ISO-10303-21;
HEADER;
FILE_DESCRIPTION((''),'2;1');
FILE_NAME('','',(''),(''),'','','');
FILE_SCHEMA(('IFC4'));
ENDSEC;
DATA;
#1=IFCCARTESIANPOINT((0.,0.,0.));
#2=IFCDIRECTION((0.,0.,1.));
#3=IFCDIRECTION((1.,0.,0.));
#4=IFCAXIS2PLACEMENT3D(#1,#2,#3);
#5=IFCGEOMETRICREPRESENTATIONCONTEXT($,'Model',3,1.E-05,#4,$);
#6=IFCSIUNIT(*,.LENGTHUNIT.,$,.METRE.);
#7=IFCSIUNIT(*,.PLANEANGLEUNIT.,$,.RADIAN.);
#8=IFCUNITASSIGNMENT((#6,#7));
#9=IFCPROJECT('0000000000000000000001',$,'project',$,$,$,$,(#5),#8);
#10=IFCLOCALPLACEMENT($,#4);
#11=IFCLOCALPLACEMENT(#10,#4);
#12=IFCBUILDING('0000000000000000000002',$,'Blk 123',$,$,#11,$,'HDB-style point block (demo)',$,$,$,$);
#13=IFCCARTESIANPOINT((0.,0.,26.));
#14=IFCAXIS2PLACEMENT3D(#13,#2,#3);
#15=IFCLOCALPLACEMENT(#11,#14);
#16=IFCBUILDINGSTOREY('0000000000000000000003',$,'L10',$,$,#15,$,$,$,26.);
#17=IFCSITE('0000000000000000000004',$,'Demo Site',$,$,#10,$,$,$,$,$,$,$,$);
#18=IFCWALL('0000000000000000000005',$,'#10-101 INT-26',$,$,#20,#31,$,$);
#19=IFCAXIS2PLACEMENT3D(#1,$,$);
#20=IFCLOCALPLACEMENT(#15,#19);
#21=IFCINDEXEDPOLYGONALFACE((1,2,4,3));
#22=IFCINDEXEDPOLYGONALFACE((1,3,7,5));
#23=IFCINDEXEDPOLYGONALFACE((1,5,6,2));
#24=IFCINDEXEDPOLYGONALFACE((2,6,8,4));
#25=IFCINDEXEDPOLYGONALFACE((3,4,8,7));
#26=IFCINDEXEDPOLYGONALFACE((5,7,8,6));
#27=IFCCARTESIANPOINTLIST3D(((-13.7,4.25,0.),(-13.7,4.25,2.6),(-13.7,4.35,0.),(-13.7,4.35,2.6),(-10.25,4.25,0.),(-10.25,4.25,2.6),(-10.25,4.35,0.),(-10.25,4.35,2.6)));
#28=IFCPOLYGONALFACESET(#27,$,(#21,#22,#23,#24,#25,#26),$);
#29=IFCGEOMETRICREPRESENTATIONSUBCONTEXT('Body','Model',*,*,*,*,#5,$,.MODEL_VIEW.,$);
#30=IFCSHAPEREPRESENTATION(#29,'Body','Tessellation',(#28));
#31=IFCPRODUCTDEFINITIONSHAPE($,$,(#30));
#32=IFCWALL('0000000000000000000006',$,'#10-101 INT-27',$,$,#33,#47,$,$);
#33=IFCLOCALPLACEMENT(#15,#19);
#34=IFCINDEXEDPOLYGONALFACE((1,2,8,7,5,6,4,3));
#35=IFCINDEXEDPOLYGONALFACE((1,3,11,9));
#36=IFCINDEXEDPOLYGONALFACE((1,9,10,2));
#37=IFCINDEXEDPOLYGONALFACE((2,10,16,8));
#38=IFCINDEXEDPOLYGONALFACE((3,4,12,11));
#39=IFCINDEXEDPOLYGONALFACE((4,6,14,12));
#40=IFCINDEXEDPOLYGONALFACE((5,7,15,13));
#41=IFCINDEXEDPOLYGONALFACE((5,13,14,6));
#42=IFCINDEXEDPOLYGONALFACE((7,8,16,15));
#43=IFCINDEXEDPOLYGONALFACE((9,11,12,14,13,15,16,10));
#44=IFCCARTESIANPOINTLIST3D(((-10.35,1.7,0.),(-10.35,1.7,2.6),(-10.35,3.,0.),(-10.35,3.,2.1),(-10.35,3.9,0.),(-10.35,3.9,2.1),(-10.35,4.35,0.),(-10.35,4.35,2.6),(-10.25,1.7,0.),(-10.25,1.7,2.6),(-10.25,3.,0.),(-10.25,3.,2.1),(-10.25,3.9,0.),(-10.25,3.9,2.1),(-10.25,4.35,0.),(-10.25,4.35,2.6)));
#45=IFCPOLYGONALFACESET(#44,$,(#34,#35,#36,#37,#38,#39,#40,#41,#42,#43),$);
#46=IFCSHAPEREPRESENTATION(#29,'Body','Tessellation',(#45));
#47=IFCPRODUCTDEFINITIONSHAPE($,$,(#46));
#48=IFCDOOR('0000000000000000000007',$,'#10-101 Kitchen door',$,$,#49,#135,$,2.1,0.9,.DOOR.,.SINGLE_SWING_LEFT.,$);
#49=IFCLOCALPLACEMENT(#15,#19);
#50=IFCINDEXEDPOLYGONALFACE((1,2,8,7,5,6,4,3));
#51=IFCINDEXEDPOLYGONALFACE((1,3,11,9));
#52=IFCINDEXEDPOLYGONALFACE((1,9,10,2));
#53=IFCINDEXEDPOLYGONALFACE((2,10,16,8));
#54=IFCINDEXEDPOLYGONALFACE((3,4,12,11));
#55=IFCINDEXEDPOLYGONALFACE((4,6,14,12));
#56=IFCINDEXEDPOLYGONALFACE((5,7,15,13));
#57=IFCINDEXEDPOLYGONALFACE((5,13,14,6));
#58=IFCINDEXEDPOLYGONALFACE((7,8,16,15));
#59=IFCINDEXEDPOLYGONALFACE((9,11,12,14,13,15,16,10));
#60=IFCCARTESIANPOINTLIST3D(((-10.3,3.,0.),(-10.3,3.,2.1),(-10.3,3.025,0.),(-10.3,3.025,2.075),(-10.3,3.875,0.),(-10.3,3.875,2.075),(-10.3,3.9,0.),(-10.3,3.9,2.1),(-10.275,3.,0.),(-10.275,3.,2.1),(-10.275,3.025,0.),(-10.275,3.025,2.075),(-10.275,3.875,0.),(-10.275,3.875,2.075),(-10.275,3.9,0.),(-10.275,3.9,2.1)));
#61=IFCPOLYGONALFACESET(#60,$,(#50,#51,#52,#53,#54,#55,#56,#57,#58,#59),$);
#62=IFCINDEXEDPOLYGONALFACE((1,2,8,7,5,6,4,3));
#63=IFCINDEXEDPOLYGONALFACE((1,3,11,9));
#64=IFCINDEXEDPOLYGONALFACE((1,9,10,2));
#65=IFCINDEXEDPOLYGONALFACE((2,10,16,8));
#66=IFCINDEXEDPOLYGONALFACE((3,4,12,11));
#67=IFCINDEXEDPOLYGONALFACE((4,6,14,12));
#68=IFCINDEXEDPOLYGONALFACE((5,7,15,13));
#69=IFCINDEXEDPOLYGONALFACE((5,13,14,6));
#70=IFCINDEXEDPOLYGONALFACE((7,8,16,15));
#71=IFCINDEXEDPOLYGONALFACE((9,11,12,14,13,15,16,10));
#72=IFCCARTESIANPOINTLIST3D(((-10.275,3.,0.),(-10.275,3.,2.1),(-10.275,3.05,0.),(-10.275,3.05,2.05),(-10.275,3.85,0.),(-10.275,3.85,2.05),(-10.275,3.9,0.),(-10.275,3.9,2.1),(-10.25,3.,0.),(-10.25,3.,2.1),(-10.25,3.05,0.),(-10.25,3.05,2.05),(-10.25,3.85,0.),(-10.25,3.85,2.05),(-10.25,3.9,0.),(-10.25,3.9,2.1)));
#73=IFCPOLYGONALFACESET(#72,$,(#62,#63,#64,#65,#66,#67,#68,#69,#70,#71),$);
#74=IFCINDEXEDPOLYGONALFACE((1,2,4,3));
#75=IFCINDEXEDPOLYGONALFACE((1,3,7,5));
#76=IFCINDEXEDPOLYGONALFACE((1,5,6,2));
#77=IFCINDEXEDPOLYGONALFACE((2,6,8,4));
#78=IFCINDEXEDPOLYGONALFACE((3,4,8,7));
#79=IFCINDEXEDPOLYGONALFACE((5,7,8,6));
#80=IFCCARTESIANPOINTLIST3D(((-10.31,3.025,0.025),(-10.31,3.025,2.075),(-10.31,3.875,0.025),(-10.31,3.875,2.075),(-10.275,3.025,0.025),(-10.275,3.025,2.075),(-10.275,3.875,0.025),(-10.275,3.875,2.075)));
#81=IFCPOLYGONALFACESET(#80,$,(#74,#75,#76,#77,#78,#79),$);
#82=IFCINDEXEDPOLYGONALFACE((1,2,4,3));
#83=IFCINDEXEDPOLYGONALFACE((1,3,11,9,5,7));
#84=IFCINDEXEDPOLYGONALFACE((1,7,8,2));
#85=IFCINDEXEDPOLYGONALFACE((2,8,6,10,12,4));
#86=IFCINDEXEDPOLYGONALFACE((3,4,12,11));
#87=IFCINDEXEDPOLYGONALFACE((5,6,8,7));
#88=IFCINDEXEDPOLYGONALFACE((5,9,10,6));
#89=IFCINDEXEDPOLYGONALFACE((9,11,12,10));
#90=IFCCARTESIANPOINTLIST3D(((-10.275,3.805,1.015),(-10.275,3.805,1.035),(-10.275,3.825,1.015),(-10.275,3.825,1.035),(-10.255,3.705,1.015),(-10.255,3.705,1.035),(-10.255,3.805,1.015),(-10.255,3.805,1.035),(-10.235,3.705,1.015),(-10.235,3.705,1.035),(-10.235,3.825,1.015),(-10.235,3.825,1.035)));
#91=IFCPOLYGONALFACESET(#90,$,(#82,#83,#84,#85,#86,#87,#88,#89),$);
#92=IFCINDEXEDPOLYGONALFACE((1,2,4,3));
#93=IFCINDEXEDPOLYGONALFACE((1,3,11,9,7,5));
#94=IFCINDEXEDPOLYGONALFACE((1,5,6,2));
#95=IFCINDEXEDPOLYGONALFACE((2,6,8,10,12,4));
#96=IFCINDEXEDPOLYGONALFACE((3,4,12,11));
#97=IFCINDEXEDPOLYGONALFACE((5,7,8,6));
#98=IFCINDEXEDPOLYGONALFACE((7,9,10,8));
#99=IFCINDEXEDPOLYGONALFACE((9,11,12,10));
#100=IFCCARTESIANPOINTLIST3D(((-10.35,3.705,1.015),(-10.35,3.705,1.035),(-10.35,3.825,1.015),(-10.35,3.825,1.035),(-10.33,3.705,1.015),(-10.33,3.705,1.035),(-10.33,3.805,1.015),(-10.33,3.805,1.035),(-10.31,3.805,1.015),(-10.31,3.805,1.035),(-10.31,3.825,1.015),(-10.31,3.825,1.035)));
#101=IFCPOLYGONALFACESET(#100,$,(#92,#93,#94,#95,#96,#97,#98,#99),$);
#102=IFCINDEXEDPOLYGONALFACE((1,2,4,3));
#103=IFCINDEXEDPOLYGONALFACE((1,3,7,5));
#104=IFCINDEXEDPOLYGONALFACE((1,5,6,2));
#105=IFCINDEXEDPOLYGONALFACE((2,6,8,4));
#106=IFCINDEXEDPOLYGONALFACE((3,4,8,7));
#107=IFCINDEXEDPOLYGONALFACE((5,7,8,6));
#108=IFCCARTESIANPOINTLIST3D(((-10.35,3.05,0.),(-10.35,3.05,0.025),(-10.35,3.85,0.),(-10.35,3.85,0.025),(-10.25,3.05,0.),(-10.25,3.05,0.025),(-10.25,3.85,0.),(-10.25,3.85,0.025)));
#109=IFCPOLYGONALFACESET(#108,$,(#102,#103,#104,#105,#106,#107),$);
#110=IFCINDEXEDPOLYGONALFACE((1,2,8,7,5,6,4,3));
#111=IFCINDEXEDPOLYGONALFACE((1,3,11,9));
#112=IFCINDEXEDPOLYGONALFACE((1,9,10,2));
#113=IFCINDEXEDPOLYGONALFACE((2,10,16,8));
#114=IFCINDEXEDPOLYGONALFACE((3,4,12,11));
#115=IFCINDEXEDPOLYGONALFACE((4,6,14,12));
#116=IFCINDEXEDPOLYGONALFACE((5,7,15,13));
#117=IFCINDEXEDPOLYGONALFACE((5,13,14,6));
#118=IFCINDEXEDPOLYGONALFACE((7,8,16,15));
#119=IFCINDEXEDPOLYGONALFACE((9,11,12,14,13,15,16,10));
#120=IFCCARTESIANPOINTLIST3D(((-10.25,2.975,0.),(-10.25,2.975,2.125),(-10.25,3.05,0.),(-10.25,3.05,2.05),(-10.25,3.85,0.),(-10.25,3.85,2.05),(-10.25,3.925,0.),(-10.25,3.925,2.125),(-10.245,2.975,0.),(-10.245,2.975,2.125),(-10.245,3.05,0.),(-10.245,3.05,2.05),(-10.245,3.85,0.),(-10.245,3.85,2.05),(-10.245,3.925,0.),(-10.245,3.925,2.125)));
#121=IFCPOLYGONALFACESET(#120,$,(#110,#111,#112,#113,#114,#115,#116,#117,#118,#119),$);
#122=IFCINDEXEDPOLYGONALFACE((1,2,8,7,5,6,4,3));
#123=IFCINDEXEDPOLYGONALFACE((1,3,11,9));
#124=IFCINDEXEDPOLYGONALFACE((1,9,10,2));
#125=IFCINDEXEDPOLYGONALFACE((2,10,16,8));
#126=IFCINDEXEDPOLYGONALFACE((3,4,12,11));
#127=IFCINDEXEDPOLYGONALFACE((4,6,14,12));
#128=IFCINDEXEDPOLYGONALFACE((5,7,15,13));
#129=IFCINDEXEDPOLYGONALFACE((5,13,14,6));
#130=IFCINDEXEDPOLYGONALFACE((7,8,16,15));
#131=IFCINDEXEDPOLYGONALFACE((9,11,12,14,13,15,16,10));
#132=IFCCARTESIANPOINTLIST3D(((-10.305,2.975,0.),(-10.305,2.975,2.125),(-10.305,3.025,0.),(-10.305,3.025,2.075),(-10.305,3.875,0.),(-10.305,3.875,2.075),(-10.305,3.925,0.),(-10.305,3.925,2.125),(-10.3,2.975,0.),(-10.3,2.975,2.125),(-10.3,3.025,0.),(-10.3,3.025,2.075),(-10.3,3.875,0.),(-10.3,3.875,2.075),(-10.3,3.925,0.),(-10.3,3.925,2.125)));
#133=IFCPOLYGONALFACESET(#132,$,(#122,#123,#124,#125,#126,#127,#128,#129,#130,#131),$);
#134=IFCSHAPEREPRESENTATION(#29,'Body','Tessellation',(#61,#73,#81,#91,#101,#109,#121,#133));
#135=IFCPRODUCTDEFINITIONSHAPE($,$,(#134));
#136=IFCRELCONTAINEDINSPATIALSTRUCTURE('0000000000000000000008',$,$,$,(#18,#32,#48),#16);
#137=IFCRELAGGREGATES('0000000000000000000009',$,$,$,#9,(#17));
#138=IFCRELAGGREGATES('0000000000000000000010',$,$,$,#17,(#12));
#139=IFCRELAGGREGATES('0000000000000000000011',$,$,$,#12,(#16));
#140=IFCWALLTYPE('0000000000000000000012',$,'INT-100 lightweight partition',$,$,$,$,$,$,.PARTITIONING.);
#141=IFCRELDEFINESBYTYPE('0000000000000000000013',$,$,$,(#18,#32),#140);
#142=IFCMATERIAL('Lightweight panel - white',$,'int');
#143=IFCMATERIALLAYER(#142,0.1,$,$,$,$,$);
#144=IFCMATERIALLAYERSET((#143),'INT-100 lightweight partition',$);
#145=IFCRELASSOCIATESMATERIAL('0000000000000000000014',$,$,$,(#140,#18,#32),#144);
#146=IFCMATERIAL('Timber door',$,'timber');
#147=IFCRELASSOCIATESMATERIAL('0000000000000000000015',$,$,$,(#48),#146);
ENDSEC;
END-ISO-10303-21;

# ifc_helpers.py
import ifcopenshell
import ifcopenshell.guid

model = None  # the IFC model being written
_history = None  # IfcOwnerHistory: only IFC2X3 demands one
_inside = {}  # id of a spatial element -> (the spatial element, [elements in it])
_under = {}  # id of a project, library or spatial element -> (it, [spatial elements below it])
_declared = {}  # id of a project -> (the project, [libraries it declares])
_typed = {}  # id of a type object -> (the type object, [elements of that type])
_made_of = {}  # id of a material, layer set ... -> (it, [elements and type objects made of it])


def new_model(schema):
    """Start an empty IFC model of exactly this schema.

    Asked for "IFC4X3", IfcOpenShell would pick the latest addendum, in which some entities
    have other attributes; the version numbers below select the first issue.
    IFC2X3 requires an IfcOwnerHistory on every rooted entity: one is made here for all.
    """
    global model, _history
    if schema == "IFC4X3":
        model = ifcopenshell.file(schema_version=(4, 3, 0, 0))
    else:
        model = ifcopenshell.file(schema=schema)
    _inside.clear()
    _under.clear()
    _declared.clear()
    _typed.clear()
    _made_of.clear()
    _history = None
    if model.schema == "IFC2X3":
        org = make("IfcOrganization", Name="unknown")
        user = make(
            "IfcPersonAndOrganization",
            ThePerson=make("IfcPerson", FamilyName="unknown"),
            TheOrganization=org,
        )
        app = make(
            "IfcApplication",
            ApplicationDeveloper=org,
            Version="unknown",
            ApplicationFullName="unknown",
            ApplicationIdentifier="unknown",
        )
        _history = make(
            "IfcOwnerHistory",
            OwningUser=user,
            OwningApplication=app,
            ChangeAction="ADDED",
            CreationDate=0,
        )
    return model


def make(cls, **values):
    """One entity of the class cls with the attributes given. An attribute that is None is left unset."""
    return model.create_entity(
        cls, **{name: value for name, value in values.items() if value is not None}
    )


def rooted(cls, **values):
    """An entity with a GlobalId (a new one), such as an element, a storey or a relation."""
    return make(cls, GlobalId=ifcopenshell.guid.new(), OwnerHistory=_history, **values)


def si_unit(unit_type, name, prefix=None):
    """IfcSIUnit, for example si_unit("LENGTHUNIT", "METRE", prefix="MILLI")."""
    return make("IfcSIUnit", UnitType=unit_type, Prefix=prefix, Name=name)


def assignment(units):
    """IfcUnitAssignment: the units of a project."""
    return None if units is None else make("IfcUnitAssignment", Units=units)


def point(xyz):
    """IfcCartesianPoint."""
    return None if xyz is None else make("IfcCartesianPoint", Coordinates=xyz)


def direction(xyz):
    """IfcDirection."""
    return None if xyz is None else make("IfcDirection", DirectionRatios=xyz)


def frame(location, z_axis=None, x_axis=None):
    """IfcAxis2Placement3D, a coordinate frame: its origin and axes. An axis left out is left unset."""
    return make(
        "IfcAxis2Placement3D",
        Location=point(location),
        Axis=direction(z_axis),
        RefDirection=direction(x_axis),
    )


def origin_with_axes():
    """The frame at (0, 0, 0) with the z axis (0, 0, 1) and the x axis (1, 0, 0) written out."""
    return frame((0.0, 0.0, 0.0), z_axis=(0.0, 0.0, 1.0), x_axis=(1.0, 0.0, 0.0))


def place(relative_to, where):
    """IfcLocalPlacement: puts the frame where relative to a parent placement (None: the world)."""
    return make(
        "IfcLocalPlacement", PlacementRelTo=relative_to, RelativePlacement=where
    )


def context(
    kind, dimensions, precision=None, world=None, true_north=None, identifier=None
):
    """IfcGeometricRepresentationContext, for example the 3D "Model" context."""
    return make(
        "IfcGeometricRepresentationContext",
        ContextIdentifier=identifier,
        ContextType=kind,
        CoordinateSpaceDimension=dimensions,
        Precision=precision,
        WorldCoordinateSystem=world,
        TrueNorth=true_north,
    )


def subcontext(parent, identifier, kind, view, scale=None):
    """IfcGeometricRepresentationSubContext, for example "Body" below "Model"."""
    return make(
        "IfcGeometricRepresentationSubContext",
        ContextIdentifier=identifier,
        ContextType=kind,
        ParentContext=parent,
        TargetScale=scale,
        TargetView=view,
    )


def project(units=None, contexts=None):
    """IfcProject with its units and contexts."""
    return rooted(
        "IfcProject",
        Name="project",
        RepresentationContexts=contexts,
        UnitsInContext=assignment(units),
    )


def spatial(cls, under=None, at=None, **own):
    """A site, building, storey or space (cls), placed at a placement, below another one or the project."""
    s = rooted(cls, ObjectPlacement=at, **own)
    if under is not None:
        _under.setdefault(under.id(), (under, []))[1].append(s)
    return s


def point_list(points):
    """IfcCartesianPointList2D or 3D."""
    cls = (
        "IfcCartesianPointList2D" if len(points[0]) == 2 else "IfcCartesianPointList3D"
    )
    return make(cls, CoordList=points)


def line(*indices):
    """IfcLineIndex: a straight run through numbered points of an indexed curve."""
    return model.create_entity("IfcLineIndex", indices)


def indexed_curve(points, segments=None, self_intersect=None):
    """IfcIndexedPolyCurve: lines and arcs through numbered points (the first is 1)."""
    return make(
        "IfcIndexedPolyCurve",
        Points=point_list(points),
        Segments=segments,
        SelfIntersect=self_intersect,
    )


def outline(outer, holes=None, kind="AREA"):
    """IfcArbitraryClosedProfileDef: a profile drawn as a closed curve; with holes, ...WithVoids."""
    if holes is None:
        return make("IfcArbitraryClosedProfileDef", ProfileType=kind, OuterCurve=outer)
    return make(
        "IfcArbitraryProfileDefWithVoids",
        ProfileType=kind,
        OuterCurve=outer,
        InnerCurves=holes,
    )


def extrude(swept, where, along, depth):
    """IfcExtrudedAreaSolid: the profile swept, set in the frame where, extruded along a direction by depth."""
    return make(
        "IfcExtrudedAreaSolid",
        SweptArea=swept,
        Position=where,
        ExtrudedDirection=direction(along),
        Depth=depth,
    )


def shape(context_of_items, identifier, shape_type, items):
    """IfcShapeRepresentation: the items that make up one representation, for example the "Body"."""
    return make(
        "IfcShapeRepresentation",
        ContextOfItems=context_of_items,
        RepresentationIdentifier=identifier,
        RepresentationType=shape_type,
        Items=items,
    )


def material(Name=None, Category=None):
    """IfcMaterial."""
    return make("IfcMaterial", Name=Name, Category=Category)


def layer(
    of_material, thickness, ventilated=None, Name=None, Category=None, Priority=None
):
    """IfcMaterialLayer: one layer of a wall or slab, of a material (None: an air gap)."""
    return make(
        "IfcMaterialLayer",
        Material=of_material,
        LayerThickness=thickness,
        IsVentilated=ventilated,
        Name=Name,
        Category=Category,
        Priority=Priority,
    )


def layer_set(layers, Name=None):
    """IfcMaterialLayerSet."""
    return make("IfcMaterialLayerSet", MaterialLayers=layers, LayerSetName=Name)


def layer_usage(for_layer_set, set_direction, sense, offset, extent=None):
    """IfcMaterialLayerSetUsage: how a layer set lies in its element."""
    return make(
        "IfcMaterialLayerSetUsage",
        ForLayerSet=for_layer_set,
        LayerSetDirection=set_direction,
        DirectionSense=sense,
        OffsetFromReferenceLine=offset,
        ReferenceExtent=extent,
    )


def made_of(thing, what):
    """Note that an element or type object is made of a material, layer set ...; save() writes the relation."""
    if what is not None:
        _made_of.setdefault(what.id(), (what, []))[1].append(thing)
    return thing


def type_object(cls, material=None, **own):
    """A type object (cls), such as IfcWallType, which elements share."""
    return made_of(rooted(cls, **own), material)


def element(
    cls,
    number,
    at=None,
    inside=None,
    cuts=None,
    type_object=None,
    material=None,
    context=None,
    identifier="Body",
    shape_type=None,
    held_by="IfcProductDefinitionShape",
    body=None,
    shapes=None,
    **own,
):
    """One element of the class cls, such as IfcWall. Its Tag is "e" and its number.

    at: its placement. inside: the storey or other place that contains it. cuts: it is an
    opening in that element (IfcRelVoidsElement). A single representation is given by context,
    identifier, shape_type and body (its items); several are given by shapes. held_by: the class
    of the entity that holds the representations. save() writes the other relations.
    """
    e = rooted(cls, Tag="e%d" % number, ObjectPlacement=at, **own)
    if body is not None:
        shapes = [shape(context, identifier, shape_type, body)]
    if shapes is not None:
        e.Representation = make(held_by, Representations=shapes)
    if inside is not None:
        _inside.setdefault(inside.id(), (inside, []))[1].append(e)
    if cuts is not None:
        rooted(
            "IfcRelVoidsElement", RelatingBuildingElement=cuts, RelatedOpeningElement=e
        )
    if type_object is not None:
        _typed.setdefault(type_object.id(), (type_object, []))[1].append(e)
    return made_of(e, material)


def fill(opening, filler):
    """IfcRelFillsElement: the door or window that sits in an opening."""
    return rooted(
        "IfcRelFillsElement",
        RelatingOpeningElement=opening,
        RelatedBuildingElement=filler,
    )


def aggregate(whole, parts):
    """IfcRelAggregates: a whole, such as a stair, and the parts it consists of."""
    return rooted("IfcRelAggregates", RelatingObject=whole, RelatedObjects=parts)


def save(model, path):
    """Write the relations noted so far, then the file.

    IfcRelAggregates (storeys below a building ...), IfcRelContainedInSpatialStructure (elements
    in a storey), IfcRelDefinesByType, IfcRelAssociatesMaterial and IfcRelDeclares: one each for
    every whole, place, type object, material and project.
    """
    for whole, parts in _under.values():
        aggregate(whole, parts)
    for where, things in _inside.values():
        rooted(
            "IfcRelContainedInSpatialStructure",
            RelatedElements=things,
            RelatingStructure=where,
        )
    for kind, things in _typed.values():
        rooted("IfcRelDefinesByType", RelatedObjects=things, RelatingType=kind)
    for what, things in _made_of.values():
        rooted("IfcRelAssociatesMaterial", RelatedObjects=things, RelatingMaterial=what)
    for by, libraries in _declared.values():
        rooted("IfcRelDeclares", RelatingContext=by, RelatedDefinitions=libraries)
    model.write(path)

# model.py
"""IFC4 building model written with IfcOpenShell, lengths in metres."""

from ifc_helpers import new_model, si_unit, frame, origin_with_axes, place, context, subcontext, project, spatial, line, indexed_curve, outline, extrude, material, layer, layer_set, layer_usage, type_object, element, fill, save


model = new_model("IFC4")

# Units and contexts
model_context = context("Model", 3, precision=1e-05, world=origin_with_axes())
body_context = subcontext(model_context, "Body", "Model", "MODEL_VIEW")
ifc_project = project(units=[si_unit("LENGTHUNIT", "METRE"), si_unit("PLANEANGLEUNIT", "RADIAN")], contexts=[model_context])

# Site, building, storey
site_placement = place(None, origin_with_axes())
site = spatial("IfcSite", under=ifc_project, at=site_placement, Name="Demo Site")
building_placement = place(site_placement, origin_with_axes())
building = spatial("IfcBuilding", under=site, at=building_placement, Name="Blk 123", LongName="HDB-style point block (demo)")
storey_placement = place(building_placement, frame((0.0, 0.0, 26.0), z_axis=(0.0, 0.0, 1.0), x_axis=(1.0, 0.0, 0.0)))
storey = spatial("IfcBuildingStorey", under=building, at=storey_placement, Name="L10", Elevation=26.0)

# Shared definitions
ifc_material_1 = material(Name="Timber door", Category="timber")

# Wall
ifc_material_2 = material(Name="Lightweight panel - white", Category="int")
ifc_layer_1 = layer(ifc_material_2, 0.1)
ifc_layer_set_1 = layer_set([ifc_layer_1], Name="INT-100 lightweight partition")
ifc_layer_usage_1 = layer_usage(ifc_layer_set_1, "AXIS2", "POSITIVE", -0.05)
wall_type_1 = type_object("IfcWallType", Name="INT-100 lightweight partition", PredefinedType="PARTITIONING", material=ifc_layer_set_1)
wall_1_placement = place(storey_placement, frame((-10.25, 4.3, 0.0), z_axis=(0.0, 0.0, 1.0), x_axis=(-1.0, 0.0, 0.0)))
element("IfcWall", 1, at=wall_1_placement, inside=storey, type_object=wall_type_1, material=ifc_layer_usage_1, Name="#10-101 INT-26", context=body_context, shape_type="SweptSolid", body=[
    extrude(outline(indexed_curve([(0.0, 0.0), (0.0, 0.1), (3.45, 0.1), (3.45, 0.0), (0.0, 0.0)], self_intersect=False)), frame((0.0, -0.05, 0.0), z_axis=(0.0, 0.0, 1.0), x_axis=(1.0, 0.0, 0.0)), (0.0, 0.0, 1.0), 2.6),
])

# Wall, opening, door
wall_2_placement = place(storey_placement, frame((-10.3, 1.7, 0.0), z_axis=(0.0, 0.0, 1.0), x_axis=(0.0, 1.0, 0.0)))
wall_2 = element("IfcWall", 2, at=wall_2_placement, inside=storey, type_object=wall_type_1, material=ifc_layer_usage_1, Name="#10-101 INT-27", context=body_context, shape_type="SweptSolid", body=[
    extrude(outline(indexed_curve([(0.0, 0.0), (0.0, 0.1), (2.65, 0.1), (2.65, 0.0), (0.0, 0.0)], self_intersect=False)), frame((0.0, -0.05, 0.0), z_axis=(0.0, 0.0, 1.0), x_axis=(1.0, 0.0, 0.0)), (0.0, 0.0, 1.0), 2.6),
])
opening_1_placement = place(wall_2_placement, frame((1.3, -0.15, 0.0), z_axis=(0.0, 0.0, 1.0), x_axis=(1.0, 0.0, 0.0)))
opening_1 = element("IfcOpeningElement", 3, at=opening_1_placement, cuts=wall_2, context=body_context, shape_type="SweptSolid", body=[
    extrude(outline(indexed_curve([(0.0, 0.0), (0.0, 0.3), (0.9, 0.3), (0.9, 0.0), (0.0, 0.0)], self_intersect=False)), origin_with_axes(), (0.0, 0.0, 1.0), 2.1),
])
door_1_placement = place(opening_1_placement, frame((0.0, 0.1, 0.0), z_axis=(0.0, 0.0, 1.0), x_axis=(1.0, 0.0, 0.0)))
door_1 = element("IfcDoor", 4, at=door_1_placement, inside=storey, material=ifc_material_1, Name="#10-101 Kitchen door", OperationType="SINGLE_SWING_LEFT", OverallHeight=2.1, OverallWidth=0.9, PredefinedType="DOOR", context=body_context, shape_type="SweptSolid", body=[
    extrude(outline(indexed_curve([(0.0, 0.0), (0.0, 2.1), (0.9, 2.1), (0.9, 0.0), (0.875, 0.0), (0.875, 2.075), (0.025, 2.075), (0.025, 0.0)], segments=[line(1, 2, 3, 4, 5, 6, 7, 8, 1)])), frame((0.0, 0.025, 0.0), z_axis=(0.0, -1.0, 0.0), x_axis=(1.0, 0.0, 0.0)), (0.0, 0.0, -1.0), 0.025),
    extrude(outline(indexed_curve([(0.0, 0.0), (0.0, 2.1), (0.9, 2.1), (0.9, 0.0), (0.85, 0.0), (0.85, 2.05), (0.05, 2.05), (0.05, 0.0)], segments=[line(1, 2, 3, 4, 5, 6, 7, 8, 1)])), frame((0.0, 0.0, 0.0), z_axis=(0.0, -1.0, 0.0), x_axis=(1.0, 0.0, 0.0)), (0.0, 0.0, -1.0), 0.025),
    extrude(outline(indexed_curve([(0.0, 0.0), (0.85, 0.0), (0.85, 0.035), (0.0, 0.035)], segments=[line(1, 2, 3, 4, 1)])), frame((0.025, 0.025, 0.025), z_axis=(0.0, 0.0, 1.0), x_axis=(1.0, 0.0, 0.0)), (0.0, 0.0, 1.0), 2.05),
    extrude(outline(indexed_curve([(0.0, 0.0), (0.0, -0.04), (-0.12, -0.04), (-0.12, -0.02), (-0.02, -0.02), (-0.02, 0.0)], segments=[line(1, 2, 3, 4, 5, 6, 1)])), frame((0.825, 0.025, 1.015), z_axis=(0.0, 0.0, 1.0), x_axis=(1.0, 0.0, 0.0)), (0.0, 0.0, 1.0), 0.02),
    extrude(outline(indexed_curve([(0.0, 0.0), (0.0, 0.04), (-0.12, 0.04), (-0.12, 0.02), (-0.02, 0.02), (-0.02, 0.0)], segments=[line(1, 2, 3, 4, 5, 6, 1)])), frame((0.825, 0.06, 1.015), z_axis=(0.0, 0.0, 1.0), x_axis=(1.0, 0.0, 0.0)), (0.0, 0.0, 1.0), 0.02),
    extrude(outline(indexed_curve([(0.0, 0.0), (0.8, 0.0), (0.8, 0.1), (0.0, 0.1)], segments=[line(1, 2, 3, 4, 1)])), frame((0.05, 0.0, 0.0), z_axis=(0.0, 0.0, 1.0), x_axis=(1.0, 0.0, 0.0)), (0.0, 0.0, 1.0), 0.025),
    extrude(outline(indexed_curve([(0.0, 0.0), (0.0, 2.125), (0.95, 2.125), (0.95, 0.0), (0.875, 0.0), (0.875, 2.05), (0.075, 2.05), (0.075, 0.0)], segments=[line(1, 2, 3, 4, 5, 6, 7, 8, 1)])), frame((-0.025, -0.005, 0.0), z_axis=(0.0, -1.0, 0.0), x_axis=(1.0, 0.0, 0.0)), (0.0, 0.0, -1.0), 0.005),
    extrude(outline(indexed_curve([(0.0, 0.0), (0.0, 2.125), (0.95, 2.125), (0.95, 0.0), (0.9, 0.0), (0.9, 2.075), (0.05, 2.075), (0.05, 0.0)], segments=[line(1, 2, 3, 4, 5, 6, 7, 8, 1)])), frame((-0.025, 0.05, 0.0), z_axis=(0.0, -1.0, 0.0), x_axis=(1.0, 0.0, 0.0)), (0.0, 0.0, -1.0), 0.005),
])
fill(opening_1, door_1)

save(model, "model.ifc")
